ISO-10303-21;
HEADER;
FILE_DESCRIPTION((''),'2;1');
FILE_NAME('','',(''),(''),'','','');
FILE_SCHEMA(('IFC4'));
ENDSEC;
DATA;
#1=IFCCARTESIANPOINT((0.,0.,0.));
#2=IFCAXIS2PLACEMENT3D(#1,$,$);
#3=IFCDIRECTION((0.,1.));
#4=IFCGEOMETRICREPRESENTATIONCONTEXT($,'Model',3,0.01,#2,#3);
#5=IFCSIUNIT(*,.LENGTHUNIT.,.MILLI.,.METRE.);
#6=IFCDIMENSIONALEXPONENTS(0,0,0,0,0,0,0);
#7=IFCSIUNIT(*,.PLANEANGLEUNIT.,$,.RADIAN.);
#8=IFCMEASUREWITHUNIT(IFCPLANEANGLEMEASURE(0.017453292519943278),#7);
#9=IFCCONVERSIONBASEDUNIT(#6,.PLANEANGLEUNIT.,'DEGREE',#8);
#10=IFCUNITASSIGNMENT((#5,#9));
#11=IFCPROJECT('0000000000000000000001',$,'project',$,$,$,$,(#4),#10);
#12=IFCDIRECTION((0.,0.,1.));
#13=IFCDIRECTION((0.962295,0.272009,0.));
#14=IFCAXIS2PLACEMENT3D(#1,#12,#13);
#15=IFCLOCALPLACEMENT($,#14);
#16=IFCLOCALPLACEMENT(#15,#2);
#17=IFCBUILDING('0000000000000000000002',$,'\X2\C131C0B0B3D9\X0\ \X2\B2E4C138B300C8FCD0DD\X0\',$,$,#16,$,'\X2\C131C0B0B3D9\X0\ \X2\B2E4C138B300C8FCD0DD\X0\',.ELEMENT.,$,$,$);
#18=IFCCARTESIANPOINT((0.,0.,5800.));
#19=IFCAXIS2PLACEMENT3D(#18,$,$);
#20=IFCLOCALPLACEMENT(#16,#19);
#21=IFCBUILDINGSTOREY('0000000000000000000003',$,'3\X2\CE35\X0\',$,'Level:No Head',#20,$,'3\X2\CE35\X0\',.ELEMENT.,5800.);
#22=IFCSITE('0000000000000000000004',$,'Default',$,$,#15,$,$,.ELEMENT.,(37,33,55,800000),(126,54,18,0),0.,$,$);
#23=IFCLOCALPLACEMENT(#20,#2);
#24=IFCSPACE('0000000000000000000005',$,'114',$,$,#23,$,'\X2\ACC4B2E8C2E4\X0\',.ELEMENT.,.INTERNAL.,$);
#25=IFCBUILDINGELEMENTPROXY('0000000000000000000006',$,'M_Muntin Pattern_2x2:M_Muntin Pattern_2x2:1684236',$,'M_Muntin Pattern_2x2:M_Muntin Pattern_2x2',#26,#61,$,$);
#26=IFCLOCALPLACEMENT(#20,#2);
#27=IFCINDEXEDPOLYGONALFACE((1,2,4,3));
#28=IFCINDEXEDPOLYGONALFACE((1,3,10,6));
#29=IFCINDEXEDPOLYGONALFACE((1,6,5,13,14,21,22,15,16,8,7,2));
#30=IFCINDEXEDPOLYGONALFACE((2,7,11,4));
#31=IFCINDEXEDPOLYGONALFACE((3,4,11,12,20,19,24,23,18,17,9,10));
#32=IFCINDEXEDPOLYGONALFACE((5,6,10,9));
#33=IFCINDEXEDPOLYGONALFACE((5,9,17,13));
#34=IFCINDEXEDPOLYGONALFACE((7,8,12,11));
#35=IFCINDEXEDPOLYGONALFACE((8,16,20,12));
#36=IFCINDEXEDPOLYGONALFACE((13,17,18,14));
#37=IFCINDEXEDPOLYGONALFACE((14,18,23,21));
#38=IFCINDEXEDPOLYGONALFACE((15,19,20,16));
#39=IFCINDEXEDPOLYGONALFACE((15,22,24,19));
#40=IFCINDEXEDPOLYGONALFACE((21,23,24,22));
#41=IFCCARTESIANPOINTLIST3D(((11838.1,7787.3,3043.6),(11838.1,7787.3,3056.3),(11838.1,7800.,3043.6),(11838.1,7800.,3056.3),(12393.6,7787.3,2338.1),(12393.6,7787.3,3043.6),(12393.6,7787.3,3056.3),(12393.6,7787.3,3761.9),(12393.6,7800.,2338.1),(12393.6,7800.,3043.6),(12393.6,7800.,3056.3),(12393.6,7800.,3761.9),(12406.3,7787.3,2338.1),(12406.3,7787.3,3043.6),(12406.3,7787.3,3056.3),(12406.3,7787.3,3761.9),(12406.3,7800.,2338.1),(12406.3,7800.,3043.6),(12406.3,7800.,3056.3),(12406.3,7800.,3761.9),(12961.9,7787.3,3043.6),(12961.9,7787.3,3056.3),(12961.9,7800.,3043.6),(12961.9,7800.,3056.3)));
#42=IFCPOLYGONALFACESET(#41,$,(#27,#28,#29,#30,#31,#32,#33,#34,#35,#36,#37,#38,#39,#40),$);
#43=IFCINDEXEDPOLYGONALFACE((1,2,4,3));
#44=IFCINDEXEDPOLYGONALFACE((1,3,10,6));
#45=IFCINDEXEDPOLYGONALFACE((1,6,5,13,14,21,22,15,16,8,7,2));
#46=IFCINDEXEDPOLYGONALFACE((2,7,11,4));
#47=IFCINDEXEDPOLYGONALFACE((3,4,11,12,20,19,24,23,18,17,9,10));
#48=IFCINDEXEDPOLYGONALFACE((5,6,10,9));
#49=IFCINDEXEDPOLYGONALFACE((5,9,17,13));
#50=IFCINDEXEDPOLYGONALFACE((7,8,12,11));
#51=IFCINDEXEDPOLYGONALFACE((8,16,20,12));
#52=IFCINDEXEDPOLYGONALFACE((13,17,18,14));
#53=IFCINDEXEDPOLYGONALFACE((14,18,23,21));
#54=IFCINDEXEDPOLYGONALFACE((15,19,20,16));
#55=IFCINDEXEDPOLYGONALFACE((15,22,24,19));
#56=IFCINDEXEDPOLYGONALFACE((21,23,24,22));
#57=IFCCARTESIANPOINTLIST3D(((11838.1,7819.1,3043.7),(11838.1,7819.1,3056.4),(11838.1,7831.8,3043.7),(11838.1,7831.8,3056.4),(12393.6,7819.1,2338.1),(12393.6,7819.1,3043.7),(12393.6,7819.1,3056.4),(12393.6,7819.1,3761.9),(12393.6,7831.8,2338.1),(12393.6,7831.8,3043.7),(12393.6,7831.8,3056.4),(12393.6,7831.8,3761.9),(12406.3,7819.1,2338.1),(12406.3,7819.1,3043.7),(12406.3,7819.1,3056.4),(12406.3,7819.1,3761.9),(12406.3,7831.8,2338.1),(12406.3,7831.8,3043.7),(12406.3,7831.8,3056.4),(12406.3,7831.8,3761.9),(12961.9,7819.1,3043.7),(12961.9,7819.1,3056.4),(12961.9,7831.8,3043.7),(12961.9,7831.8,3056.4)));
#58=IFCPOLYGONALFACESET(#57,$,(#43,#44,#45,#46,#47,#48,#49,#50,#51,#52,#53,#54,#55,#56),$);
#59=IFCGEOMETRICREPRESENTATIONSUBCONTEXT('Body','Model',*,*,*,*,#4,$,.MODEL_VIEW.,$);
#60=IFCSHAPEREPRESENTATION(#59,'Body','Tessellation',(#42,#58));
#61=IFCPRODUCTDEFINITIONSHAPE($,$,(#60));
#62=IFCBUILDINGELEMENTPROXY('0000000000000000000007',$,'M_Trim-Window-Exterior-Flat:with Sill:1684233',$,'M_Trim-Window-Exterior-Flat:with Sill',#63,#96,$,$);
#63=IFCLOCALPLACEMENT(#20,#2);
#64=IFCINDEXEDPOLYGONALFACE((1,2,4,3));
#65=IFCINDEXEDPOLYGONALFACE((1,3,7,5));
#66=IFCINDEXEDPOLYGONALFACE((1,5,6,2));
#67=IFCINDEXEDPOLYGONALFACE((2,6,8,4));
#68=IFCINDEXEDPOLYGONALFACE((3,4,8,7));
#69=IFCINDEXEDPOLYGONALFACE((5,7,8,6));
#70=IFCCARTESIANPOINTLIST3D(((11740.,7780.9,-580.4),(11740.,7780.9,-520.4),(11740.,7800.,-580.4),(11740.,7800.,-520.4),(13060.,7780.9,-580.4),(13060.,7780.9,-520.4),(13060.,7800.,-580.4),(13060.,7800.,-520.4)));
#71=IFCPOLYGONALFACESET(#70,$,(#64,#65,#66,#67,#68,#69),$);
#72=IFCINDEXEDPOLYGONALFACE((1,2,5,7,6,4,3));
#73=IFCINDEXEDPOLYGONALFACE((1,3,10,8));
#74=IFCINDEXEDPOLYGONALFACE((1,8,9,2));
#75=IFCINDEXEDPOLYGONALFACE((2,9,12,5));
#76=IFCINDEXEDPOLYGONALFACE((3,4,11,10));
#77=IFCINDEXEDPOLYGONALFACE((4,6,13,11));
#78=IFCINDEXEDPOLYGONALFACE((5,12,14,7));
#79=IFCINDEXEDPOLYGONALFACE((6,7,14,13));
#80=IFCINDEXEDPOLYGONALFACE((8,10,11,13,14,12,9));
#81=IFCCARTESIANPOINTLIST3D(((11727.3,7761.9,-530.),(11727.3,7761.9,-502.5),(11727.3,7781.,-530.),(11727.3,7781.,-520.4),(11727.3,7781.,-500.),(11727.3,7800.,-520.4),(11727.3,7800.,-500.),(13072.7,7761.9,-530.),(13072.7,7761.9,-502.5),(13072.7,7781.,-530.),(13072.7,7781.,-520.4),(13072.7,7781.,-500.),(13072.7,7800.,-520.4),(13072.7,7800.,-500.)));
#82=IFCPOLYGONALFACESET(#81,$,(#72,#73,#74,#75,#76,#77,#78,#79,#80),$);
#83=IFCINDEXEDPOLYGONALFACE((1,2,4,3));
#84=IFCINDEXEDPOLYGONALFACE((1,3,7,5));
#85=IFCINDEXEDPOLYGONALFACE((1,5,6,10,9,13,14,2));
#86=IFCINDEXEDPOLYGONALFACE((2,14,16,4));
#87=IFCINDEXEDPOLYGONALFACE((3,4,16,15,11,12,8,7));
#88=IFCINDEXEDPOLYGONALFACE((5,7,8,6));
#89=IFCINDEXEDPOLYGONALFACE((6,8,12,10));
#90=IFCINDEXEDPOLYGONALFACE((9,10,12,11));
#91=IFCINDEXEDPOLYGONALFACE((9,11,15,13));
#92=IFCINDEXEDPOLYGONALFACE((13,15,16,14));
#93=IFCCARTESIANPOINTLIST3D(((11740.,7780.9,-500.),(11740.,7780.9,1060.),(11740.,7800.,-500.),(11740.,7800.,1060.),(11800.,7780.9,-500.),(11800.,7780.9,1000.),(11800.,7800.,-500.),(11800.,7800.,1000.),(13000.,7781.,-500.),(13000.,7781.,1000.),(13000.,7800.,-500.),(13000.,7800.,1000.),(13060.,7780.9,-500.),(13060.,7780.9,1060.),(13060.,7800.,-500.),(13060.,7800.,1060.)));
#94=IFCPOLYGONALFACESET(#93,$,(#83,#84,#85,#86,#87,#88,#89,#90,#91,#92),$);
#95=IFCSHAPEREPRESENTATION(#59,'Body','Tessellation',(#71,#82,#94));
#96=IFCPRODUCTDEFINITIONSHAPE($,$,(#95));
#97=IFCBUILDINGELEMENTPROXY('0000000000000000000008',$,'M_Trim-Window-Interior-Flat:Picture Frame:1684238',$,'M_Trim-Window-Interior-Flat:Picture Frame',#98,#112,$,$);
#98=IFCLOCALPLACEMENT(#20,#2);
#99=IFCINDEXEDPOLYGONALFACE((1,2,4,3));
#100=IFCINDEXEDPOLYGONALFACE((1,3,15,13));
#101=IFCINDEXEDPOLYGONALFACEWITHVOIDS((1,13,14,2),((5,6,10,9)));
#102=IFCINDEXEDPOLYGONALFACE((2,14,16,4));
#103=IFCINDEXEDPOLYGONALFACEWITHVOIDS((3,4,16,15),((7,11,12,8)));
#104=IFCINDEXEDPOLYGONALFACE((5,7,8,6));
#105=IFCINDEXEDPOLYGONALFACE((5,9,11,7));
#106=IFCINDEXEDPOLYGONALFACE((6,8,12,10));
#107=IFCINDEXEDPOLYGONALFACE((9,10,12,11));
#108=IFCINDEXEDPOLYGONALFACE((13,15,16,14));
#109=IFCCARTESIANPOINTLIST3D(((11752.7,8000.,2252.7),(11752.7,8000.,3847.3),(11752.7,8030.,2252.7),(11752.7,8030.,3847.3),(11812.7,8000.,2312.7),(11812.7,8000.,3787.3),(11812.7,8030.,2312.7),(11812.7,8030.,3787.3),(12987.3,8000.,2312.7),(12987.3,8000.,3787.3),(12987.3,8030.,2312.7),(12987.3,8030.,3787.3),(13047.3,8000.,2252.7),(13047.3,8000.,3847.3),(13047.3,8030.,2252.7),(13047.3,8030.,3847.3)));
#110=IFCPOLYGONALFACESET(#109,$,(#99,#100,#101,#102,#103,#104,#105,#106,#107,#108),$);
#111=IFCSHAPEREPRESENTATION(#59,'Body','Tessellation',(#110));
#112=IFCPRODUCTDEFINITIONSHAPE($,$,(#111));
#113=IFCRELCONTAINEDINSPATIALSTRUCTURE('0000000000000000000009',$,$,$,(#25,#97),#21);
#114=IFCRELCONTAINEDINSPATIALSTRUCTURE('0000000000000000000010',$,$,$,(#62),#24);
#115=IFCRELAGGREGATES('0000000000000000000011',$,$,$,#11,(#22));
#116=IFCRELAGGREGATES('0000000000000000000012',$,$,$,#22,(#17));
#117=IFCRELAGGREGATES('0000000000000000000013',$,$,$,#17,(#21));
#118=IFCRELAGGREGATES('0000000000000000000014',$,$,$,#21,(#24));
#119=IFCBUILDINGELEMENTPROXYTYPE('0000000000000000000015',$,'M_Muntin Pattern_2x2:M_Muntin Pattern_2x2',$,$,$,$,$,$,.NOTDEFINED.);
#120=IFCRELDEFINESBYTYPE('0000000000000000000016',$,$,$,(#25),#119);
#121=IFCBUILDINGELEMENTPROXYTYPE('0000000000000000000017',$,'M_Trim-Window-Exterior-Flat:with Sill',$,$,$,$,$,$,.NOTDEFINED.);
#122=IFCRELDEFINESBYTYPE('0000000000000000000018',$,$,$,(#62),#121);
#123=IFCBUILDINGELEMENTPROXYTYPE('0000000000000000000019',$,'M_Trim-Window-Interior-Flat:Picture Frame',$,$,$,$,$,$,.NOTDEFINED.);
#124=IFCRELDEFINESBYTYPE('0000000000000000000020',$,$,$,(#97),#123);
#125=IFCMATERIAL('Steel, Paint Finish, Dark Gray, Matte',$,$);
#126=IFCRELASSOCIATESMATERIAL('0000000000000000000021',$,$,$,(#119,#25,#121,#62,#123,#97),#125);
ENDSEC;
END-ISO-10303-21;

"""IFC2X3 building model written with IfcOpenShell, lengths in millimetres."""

from ifc_helpers import new_model, entity, si_unit, converted_unit, direction, frame, frame_2d, origin, place, context, subcontext, project, spatial, polyline, rectangle, outline, extrude, source, transform, mapped, material, type_object, type_shapes, element, save


model = new_model("IFC2X3")

# Units and contexts
model_context = context("Model", 3, precision=0.01, world=origin(), true_north=direction((0.0, 1.0)))
body_context = subcontext(model_context, "Body", "Model", "MODEL_VIEW")
ifc_project = project(units=[si_unit("LENGTHUNIT", "METRE", prefix="MILLI"), converted_unit("PLANEANGLEUNIT", "DEGREE", entity("IfcPlaneAngleMeasure", 0.017453292519943278), si_unit("PLANEANGLEUNIT", "RADIAN"), dimensions=[0, 0, 0, 0, 0, 0, 0])], contexts=[model_context])

# Site, building, storey
site_placement = place(None, frame((0.0, 0.0, 0.0), z_axis=(0.0, 0.0, 1.0), x_axis=(0.962295, 0.272009, 0.0)))
site = spatial("IfcSite", under=ifc_project, at=site_placement, Name="Default", CompositionType="ELEMENT", RefLatitude=(37, 33, 55, 800000), RefLongitude=(126, 54, 18, 0), RefElevation=0.0)
building_placement = place(site_placement, origin())
building = spatial("IfcBuilding", under=site, at=building_placement, Name="성산동 다세대주택", LongName="성산동 다세대주택", CompositionType="ELEMENT")
storey_placement = place(building_placement, frame((0.0, 0.0, 5800.0)))
storey = spatial("IfcBuildingStorey", under=building, at=storey_placement, Name="3층", ObjectType="Level:No Head", LongName="3층", CompositionType="ELEMENT", Elevation=5800.0)

# Shared definitions
ifc_material_1 = material(Name="Steel, Paint Finish, Dark Gray, Matte")

# Building element proxy
building_element_proxy_type_1 = type_object("IfcBuildingElementProxyType", Name="M_Muntin Pattern_2x2:M_Muntin Pattern_2x2", PredefinedType="NOTDEFINED", material=ifc_material_1)
shared_shape_1 = source(origin(), body_context, "Body", "SweptSolid", [
    extrude(outline(polyline([(6.4, -6.4), (711.9, -6.4), (711.9, 6.3), (6.4, 6.3), (6.4, 561.9), (-6.3, 561.9), (-6.3, 6.3), (-711.9, 6.3), (-711.9, -6.4), (-6.3, -6.4), (-6.3, -561.9), (6.4, -561.9), (6.4, -6.4)])), frame((0.0, -22.2, 711.9), z_axis=(0.0, 1.0, 0.0), x_axis=(0.0, 0.0, 1.0)), (0.0, 0.0, 1.0), 12.7),
    extrude(outline(polyline([(6.4, -6.4), (711.9, -6.4), (711.9, 6.3), (6.4, 6.3), (6.4, 561.9), (-6.3, 561.9), (-6.3, 6.3), (-711.9, 6.3), (-711.9, -6.4), (-6.3, -6.4), (-6.3, -561.9), (6.4, -561.9), (6.4, -6.4)])), frame((0.0, 9.5, 711.9), z_axis=(0.0, 1.0, 0.0), x_axis=(0.0, 0.0, 1.0)), (0.0, 0.0, 1.0), 12.7),
])
type_shapes(building_element_proxy_type_1, [shared_shape_1])
proxy_1_placement = place(storey_placement, frame((12400.0, 7809.5, 2338.1)))
element("IfcBuildingElementProxy", 1, at=proxy_1_placement, inside=storey, type_object=building_element_proxy_type_1, material=ifc_material_1, Name="M_Muntin Pattern_2x2:M_Muntin Pattern_2x2:1684236", ObjectType="M_Muntin Pattern_2x2:M_Muntin Pattern_2x2", context=body_context, shape_type="MappedRepresentation", body=[
    mapped(shared_shape_1, transform((0.0, 0.0, 0.0), scale=1.0)),
])

# Shared definitions
space_1_placement = place(storey_placement, origin())
space_1 = spatial("IfcSpace", under=storey, at=space_1_placement, Name="114", LongName="계단실", CompositionType="ELEMENT", InteriorOrExteriorSpace="INTERNAL")

# Building element proxies
building_element_proxy_type_2 = type_object("IfcBuildingElementProxyType", Name="M_Trim-Window-Exterior-Flat:with Sill", PredefinedType="NOTDEFINED", material=ifc_material_1)
shared_shape_2 = source(origin(), body_context, "Body", "SweptSolid", [
    extrude(rectangle(XDim=1320.0, YDim=60.0, at=frame_2d((0.0, 0.0), x_axis=(1.0, 0.0))), frame((0.0, -1550.4, 0.0), z_axis=(0.0, 0.0, 1.0), x_axis=(-1.0, 0.0, 0.0)), (0.0, 0.0, 1.0), 19.0),
    extrude(outline(polyline([(-19.0, -15.2), (0.0, -15.2), (0.0, -5.7), (19.0, -5.7), (19.0, 14.8), (0.0, 14.8), (-19.0, 12.3), (-19.0, -15.2)])), frame((-672.7, -1514.8, 19.0), z_axis=(1.0, 0.0, 0.0), x_axis=(0.0, 0.0, -1.0)), (0.0, 0.0, 1.0), 1345.4),
    extrude(outline(polyline([(-795.0, -660.0), (765.0, -660.0), (765.0, -600.0), (-735.0, -600.0), (-735.0, 600.0), (765.0, 600.0), (765.0, 660.0), (-795.0, 660.0), (-795.0, -660.0)])), frame((0.0, -735.0, 0.0), z_axis=(0.0, 0.0, 1.0), x_axis=(0.0, -1.0, 0.0)), (0.0, 0.0, 1.0), 19.0),
])
type_shapes(building_element_proxy_type_2, [shared_shape_2])
proxy_2_placement = place(space_1_placement, frame((12400.0, 7800.0, 1000.0), z_axis=(0.0, -1.0, 0.0), x_axis=(1.0, 0.0, 0.0)))
element("IfcBuildingElementProxy", 2, at=proxy_2_placement, inside=space_1, type_object=building_element_proxy_type_2, material=ifc_material_1, Name="M_Trim-Window-Exterior-Flat:with Sill:1684233", ObjectType="M_Trim-Window-Exterior-Flat:with Sill", context=body_context, shape_type="MappedRepresentation", body=[
    mapped(shared_shape_2, transform((0.0, 0.0, 0.0), scale=1.0)),
])
building_element_proxy_type_3 = type_object("IfcBuildingElementProxyType", Name="M_Trim-Window-Interior-Flat:Picture Frame", PredefinedType="NOTDEFINED", material=ifc_material_1)
shared_shape_3 = source(origin(), body_context, "Body", "SweptSolid", [
    extrude(outline(polyline([(-647.3, -797.3), (647.3, -797.3), (647.3, 797.3), (-647.3, 797.3), (-647.3, -797.3)]), holes=[polyline([(-587.3, -737.3), (-587.3, 737.3), (587.3, 737.3), (587.3, -737.3), (-587.3, -737.3)])]), frame((0.0, -750.0, 0.0), z_axis=(0.0, 0.0, 1.0), x_axis=(-1.0, 0.0, 0.0)), (0.0, 0.0, 1.0), 30.0),
])
type_shapes(building_element_proxy_type_3, [shared_shape_3])
proxy_3_placement = place(storey_placement, frame((12400.0, 8000.0, 3800.0), z_axis=(0.0, 1.0, 0.0), x_axis=(-1.0, 0.0, 0.0)))
element("IfcBuildingElementProxy", 3, at=proxy_3_placement, inside=storey, type_object=building_element_proxy_type_3, material=ifc_material_1, Name="M_Trim-Window-Interior-Flat:Picture Frame:1684238", ObjectType="M_Trim-Window-Interior-Flat:Picture Frame", context=body_context, shape_type="MappedRepresentation", body=[
    mapped(shared_shape_3, transform((0.0, 0.0, 0.0), scale=1.0)),
])

save(model, "model.ifc")
